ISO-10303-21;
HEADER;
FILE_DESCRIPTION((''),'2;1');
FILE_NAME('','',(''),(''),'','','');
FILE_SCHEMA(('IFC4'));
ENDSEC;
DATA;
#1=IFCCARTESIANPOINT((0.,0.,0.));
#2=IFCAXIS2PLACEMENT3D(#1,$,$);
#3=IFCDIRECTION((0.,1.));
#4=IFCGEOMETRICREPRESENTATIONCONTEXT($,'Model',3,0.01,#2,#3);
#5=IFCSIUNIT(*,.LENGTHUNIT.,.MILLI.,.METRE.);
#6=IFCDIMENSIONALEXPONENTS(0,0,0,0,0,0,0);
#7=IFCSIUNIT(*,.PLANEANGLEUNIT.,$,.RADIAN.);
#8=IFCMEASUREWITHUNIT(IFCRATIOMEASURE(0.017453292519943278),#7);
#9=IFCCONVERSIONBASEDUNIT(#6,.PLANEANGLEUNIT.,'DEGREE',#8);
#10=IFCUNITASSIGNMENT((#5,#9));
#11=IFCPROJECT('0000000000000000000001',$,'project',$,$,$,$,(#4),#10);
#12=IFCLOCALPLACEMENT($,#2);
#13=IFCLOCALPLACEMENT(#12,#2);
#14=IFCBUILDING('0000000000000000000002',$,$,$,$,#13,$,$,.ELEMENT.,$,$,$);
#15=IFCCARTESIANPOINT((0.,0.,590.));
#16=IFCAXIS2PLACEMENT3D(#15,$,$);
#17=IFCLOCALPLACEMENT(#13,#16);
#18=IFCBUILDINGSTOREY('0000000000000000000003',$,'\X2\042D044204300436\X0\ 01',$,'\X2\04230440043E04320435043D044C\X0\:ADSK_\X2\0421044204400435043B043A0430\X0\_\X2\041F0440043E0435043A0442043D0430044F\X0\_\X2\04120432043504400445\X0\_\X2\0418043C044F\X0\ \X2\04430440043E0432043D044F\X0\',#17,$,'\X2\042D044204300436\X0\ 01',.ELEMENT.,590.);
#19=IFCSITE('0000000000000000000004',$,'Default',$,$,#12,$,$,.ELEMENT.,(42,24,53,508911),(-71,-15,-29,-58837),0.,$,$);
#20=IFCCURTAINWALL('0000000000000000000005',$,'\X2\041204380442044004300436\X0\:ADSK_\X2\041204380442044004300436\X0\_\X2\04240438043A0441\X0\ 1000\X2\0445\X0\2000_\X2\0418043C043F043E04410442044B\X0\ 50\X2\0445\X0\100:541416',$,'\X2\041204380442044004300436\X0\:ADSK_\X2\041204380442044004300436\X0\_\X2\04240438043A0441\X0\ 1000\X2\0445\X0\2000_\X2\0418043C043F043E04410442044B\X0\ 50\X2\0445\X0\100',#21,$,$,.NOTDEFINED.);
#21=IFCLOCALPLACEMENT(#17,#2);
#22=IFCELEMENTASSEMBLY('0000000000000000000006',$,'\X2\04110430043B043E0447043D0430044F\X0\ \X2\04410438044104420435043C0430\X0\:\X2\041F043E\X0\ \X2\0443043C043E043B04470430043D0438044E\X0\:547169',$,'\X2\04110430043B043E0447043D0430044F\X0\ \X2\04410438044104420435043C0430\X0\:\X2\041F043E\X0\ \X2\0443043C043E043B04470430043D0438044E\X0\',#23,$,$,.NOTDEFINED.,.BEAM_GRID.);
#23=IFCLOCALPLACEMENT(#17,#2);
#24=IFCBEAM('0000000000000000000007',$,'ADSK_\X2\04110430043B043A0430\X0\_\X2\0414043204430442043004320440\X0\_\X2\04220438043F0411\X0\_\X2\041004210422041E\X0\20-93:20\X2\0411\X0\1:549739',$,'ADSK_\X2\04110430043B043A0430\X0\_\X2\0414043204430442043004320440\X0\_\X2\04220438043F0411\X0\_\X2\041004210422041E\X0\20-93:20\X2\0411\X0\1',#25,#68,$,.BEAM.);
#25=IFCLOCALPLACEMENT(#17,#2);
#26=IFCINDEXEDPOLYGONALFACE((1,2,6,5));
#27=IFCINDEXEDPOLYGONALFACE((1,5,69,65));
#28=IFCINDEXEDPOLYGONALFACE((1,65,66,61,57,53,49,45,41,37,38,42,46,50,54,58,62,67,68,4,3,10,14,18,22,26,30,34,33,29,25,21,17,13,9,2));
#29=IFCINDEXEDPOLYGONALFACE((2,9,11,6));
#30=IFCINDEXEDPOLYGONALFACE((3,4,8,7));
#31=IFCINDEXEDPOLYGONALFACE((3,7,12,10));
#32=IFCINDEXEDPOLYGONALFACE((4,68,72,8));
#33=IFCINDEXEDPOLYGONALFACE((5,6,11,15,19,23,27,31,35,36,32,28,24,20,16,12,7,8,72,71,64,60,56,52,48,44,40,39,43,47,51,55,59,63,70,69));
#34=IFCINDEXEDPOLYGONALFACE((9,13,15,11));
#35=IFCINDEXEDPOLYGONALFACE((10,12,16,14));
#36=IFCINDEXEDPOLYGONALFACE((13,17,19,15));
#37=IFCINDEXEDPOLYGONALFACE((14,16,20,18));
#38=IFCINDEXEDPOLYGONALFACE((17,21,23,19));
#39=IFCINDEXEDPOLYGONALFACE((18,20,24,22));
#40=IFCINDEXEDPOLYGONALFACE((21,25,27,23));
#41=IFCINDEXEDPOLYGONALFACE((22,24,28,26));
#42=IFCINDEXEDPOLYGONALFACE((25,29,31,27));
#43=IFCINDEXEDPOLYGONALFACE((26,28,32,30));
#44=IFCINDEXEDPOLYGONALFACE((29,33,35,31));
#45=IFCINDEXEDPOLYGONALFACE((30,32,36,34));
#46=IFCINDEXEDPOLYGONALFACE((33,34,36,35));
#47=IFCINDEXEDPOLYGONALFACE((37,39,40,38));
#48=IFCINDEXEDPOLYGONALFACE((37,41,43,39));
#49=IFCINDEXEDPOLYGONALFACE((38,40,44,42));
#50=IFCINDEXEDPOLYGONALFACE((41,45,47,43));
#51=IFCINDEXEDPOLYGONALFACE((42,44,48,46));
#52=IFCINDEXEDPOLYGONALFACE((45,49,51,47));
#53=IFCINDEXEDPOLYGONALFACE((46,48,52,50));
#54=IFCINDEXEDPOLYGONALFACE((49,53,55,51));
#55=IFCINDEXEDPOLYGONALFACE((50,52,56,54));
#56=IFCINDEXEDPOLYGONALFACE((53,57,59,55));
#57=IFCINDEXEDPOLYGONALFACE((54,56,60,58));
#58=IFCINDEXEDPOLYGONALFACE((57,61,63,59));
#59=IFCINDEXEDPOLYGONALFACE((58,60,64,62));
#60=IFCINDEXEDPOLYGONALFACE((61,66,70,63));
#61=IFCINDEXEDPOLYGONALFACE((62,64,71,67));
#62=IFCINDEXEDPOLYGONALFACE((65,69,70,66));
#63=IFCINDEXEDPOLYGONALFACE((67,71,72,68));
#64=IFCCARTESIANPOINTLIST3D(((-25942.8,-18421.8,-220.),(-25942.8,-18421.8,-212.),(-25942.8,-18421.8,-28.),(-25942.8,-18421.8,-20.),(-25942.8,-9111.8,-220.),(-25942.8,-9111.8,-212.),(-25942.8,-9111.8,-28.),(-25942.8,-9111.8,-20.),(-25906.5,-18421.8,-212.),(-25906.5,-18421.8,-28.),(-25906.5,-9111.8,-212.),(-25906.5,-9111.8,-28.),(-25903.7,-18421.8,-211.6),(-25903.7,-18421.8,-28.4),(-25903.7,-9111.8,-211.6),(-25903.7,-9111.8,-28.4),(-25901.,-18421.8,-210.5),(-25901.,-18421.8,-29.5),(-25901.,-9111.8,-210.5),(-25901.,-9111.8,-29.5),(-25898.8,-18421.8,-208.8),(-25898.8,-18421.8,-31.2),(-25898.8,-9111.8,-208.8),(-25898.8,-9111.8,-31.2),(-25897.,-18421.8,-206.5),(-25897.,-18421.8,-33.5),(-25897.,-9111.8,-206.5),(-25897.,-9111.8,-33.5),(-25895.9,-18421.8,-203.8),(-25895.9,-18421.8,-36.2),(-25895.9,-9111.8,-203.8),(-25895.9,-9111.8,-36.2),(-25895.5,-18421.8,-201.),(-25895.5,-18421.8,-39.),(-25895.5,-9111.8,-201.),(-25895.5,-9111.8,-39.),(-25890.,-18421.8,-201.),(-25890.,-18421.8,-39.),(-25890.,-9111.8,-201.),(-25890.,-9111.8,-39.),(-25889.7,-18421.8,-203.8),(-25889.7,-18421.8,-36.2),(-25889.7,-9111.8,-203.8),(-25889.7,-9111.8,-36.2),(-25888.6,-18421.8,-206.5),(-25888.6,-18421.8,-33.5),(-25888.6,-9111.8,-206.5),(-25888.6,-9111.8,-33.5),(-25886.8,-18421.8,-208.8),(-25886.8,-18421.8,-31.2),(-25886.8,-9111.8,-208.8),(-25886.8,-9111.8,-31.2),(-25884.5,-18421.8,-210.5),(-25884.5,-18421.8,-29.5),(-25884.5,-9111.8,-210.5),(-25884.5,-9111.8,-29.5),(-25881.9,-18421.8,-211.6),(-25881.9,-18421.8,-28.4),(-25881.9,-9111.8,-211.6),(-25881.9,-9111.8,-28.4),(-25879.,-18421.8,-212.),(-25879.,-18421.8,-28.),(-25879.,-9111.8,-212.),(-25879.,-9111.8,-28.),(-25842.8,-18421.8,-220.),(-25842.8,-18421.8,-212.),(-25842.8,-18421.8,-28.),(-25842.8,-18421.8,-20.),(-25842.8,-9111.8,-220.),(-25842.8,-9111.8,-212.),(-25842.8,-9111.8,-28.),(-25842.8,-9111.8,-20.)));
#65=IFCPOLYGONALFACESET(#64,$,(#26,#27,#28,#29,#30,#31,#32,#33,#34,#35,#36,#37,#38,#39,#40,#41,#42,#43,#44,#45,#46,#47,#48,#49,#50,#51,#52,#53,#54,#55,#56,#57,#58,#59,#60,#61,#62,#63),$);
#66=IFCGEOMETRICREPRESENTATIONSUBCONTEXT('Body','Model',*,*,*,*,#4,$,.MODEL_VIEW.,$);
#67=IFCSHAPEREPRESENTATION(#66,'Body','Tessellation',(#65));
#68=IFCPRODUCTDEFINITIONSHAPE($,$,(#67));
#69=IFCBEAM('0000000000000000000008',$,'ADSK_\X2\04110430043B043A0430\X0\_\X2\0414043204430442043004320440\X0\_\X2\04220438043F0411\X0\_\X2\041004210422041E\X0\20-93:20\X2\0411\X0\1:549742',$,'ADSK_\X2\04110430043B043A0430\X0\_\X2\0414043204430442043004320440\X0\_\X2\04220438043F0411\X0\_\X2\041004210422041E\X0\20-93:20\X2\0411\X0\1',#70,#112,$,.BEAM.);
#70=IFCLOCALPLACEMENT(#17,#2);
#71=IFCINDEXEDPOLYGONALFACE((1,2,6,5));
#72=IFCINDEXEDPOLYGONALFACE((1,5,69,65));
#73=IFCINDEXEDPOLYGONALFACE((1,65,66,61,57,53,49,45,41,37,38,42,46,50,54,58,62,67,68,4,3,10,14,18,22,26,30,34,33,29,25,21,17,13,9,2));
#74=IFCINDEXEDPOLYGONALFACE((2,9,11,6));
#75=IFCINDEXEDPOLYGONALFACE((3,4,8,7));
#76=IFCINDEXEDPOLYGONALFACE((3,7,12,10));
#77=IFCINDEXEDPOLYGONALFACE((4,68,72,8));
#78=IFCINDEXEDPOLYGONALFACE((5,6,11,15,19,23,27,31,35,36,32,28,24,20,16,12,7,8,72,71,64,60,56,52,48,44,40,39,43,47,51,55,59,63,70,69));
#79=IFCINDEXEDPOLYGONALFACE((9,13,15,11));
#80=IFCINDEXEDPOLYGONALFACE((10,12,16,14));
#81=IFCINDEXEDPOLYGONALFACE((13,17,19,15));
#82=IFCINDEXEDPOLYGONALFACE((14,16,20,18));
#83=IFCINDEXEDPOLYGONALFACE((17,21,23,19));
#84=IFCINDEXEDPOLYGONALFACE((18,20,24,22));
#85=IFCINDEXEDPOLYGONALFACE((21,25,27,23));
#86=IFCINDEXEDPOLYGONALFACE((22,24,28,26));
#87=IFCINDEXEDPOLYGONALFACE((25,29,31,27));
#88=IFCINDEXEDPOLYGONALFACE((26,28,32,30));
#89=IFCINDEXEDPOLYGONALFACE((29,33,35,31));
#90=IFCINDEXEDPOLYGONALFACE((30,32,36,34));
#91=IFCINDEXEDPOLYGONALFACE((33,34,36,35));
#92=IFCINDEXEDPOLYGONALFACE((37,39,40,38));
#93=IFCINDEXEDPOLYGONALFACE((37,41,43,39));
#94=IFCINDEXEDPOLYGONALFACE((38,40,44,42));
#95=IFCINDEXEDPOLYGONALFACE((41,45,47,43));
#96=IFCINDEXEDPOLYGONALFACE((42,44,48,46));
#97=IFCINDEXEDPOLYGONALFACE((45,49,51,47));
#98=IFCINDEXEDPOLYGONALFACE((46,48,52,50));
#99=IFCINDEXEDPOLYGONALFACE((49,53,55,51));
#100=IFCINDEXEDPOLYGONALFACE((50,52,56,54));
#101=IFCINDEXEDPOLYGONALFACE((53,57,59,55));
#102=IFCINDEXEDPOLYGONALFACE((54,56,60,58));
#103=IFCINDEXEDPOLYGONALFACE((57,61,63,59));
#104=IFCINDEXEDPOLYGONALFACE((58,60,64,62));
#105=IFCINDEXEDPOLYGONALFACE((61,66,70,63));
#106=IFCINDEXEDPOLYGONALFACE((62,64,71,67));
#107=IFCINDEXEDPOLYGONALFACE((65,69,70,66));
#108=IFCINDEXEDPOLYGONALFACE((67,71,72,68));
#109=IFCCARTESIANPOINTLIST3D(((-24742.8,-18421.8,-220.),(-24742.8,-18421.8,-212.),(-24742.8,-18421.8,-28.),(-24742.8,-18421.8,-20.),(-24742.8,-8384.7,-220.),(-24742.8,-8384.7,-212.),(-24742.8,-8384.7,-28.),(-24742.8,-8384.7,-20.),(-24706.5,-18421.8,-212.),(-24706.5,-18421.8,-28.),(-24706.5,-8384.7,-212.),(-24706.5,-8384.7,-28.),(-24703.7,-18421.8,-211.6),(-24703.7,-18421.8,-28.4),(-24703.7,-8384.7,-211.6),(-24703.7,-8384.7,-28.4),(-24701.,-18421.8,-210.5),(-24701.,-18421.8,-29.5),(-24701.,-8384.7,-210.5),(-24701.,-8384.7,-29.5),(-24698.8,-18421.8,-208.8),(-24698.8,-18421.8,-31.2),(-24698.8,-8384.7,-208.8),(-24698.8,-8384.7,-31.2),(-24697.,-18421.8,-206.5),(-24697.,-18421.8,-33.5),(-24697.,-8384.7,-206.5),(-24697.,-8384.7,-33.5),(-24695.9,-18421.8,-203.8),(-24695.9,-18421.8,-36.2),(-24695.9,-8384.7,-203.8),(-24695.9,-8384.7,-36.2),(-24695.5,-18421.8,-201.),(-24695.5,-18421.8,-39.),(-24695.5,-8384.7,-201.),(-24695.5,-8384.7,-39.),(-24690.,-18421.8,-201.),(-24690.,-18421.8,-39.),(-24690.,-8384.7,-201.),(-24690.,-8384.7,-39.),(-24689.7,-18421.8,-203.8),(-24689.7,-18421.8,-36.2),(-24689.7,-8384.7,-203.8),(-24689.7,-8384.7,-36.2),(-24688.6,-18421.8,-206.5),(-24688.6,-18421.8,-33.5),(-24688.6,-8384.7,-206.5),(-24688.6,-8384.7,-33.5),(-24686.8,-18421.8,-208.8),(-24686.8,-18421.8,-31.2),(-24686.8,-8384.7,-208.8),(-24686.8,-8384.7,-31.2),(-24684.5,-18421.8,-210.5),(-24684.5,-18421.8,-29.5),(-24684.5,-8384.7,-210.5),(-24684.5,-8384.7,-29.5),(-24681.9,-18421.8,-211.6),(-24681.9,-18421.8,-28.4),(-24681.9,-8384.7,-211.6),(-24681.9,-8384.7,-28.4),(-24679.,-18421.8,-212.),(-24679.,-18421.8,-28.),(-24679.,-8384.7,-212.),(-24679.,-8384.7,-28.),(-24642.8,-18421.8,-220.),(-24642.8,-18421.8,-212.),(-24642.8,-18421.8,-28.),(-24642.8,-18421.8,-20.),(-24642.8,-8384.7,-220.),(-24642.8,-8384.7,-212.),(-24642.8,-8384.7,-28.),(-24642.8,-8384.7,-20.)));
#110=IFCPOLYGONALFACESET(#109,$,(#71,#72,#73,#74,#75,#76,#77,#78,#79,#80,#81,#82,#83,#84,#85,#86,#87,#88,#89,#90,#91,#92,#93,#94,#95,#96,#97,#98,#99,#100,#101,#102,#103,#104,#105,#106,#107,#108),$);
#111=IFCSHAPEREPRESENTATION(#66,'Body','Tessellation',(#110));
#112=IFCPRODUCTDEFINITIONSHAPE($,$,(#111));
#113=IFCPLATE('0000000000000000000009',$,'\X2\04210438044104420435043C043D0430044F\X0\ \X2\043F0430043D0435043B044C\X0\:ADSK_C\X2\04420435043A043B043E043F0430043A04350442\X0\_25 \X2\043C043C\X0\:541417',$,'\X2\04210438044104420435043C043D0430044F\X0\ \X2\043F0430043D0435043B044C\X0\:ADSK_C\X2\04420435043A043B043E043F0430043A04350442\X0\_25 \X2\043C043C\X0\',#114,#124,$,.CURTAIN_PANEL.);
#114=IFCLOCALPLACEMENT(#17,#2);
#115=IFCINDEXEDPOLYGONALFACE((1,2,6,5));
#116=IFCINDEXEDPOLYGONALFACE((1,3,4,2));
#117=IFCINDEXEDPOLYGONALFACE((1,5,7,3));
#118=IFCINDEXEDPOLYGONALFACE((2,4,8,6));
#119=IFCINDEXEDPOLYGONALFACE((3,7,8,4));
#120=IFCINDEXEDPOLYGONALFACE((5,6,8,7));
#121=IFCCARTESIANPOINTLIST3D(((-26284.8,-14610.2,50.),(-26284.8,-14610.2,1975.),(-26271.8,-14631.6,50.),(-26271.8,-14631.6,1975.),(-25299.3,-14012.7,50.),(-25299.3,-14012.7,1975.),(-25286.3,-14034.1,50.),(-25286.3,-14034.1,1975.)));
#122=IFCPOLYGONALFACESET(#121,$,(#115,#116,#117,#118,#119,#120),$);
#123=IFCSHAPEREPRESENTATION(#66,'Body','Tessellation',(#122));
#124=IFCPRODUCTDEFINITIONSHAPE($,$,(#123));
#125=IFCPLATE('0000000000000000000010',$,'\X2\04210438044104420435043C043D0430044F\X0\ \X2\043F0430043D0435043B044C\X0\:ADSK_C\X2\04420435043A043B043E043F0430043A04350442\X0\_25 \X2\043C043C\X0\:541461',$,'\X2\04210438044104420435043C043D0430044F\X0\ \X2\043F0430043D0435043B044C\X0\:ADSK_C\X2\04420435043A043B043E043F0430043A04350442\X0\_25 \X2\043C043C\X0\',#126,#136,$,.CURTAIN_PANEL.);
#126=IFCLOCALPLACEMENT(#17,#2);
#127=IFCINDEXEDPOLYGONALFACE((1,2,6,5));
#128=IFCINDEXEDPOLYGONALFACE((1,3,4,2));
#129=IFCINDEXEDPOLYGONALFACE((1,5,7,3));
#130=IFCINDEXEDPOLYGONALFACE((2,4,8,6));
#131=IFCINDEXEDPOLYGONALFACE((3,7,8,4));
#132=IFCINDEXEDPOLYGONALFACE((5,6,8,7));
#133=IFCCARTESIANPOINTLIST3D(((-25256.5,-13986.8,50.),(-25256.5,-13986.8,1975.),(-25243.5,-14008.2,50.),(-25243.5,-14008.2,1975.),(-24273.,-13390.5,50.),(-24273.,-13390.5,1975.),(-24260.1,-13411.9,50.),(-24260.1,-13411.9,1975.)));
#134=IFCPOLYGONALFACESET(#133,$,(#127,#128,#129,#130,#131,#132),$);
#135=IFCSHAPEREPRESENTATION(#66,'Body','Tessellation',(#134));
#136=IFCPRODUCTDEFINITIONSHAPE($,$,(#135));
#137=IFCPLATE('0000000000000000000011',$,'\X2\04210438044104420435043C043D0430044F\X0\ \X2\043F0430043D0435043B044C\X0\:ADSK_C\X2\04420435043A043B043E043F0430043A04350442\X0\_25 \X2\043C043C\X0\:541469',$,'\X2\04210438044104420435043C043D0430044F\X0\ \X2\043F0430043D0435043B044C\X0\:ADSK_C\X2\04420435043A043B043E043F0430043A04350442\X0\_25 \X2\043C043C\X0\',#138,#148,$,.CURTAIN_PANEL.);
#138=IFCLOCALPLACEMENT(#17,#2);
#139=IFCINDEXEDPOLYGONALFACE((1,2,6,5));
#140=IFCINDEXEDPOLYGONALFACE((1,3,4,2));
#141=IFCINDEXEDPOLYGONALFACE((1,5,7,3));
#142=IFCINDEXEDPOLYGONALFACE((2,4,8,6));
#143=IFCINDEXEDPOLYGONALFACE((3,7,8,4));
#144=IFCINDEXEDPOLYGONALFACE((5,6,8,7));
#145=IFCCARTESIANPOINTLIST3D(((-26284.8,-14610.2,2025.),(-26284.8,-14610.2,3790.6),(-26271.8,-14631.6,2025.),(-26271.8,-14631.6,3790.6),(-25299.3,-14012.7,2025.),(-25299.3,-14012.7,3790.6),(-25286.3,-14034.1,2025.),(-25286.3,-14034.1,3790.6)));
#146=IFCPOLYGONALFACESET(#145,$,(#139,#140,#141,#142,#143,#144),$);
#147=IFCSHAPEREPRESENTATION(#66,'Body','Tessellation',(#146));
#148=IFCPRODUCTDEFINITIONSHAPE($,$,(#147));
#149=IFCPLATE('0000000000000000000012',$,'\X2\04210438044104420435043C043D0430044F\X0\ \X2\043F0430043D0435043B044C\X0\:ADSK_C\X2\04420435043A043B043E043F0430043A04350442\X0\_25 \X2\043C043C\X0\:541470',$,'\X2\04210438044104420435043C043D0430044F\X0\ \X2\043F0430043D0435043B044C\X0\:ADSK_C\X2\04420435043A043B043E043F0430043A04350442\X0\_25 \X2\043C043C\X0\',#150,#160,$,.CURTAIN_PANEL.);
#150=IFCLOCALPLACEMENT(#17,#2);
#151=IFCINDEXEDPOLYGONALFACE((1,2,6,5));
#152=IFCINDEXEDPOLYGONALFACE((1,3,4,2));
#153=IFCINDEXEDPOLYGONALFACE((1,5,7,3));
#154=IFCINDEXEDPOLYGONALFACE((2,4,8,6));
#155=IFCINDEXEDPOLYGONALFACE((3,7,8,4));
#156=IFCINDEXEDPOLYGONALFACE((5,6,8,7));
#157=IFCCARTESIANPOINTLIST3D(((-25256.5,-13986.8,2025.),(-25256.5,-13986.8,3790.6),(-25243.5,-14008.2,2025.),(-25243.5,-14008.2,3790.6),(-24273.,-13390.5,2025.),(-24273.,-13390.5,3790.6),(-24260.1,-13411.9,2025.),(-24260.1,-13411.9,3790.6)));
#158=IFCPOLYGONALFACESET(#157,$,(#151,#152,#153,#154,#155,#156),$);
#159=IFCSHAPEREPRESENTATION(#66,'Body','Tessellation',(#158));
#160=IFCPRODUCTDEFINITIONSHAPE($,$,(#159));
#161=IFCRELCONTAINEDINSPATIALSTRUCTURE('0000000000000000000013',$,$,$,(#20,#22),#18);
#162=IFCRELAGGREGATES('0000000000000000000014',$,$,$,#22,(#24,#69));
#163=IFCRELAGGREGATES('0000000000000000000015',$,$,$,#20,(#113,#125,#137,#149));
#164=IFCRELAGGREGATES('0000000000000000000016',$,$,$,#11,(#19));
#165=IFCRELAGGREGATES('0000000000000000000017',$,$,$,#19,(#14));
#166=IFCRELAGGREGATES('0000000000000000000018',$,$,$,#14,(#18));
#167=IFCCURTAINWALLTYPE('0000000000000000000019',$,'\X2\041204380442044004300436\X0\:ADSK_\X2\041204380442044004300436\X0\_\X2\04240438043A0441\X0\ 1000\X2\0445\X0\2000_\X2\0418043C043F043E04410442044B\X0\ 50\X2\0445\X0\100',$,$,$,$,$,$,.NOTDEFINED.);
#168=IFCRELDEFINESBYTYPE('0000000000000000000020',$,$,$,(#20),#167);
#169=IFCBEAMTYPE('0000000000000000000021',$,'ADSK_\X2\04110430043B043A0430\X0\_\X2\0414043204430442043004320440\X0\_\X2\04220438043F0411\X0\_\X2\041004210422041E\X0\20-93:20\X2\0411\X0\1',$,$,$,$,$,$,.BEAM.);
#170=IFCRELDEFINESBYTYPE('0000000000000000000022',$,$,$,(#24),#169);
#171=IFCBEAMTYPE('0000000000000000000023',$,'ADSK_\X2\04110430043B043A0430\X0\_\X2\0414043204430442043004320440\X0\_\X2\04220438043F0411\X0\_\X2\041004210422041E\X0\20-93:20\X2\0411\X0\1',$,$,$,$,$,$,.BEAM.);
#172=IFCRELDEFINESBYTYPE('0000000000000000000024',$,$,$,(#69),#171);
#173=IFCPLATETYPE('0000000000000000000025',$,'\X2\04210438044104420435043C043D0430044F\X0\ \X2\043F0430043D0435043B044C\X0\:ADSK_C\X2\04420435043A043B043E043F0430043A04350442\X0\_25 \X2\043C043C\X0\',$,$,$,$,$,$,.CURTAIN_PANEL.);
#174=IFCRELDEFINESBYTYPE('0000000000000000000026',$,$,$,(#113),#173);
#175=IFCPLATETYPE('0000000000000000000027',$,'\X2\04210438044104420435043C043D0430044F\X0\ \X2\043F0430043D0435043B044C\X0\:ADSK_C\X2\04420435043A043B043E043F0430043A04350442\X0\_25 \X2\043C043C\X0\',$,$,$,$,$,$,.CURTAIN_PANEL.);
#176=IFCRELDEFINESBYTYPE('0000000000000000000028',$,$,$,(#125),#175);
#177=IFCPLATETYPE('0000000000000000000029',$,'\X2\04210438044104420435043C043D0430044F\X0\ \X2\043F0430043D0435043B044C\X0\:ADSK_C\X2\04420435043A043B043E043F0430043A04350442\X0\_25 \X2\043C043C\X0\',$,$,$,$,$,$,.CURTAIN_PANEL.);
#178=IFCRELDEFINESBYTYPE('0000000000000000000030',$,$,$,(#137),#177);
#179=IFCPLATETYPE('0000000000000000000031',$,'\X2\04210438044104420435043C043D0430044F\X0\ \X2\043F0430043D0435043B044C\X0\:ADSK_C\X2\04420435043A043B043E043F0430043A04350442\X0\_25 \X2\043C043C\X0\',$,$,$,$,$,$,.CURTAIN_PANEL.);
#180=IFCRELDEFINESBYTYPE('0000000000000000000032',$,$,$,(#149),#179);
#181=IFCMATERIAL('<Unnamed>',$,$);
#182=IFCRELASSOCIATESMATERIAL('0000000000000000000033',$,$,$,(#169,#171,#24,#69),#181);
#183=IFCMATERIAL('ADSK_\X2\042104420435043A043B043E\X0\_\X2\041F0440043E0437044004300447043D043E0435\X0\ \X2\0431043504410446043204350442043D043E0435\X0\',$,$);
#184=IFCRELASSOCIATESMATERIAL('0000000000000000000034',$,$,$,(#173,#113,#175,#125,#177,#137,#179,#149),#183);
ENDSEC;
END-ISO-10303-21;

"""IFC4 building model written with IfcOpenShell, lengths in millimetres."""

from ifc_helpers import new_model, entity, si_unit, converted_unit, direction, frame, frame_2d, origin, place, context, subcontext, project, spatial, polyline, circle_curve, parameter, trimmed, segment, composite_curve, rectangle, i_section, outline, extrude, source, transform, mapped, material, material_profile, profile_set, profile_usage, type_object, type_shapes, element, aggregate, save


model = new_model("IFC4")

# Units and contexts
model_context = context("Model", 3, precision=0.01, world=origin(), true_north=direction((0.0, 1.0)))
body_context = subcontext(model_context, "Body", "Model", "MODEL_VIEW")
ifc_project = project(units=[si_unit("LENGTHUNIT", "METRE", prefix="MILLI"), converted_unit("PLANEANGLEUNIT", "DEGREE", entity("IfcRatioMeasure", 0.017453292519943278), si_unit("PLANEANGLEUNIT", "RADIAN"), dimensions=[0, 0, 0, 0, 0, 0, 0])], contexts=[model_context])

# Site, building, storey
site_placement = place(None, origin())
site = spatial("IfcSite", under=ifc_project, at=site_placement, Name="Default", CompositionType="ELEMENT", RefLatitude=(42, 24, 53, 508911), RefLongitude=(-71, -15, -29, -58837), RefElevation=0.0)
building_placement = place(site_placement, origin())
building = spatial("IfcBuilding", under=site, at=building_placement, CompositionType="ELEMENT")
storey_placement = place(building_placement, frame((0.0, 0.0, 590.0)))
storey = spatial("IfcBuildingStorey", under=building, at=storey_placement, Name="Этаж 01", ObjectType="Уровень:ADSK_Стрелка_Проектная_Вверх_Имя уровня", LongName="Этаж 01", CompositionType="ELEMENT", Elevation=590.0)

# Curtain wall
curtain_wall_type = type_object("IfcCurtainWallType", Name="Витраж:ADSK_Витраж_Фикс 1000х2000_Импосты 50х100", PredefinedType="NOTDEFINED")
curtain_wall_placement = place(storey_placement, frame((0.0, 0.0, -590.0)))
curtain_wall = element("IfcCurtainWall", 1, at=curtain_wall_placement, inside=storey, type_object=curtain_wall_type, Name="Витраж:ADSK_Витраж_Фикс 1000х2000_Импосты 50х100:541416", ObjectType="Витраж:ADSK_Витраж_Фикс 1000х2000_Импосты 50х100", PredefinedType="NOTDEFINED")
ifc_material_1 = material(Name="<Unnamed>")

# Element assembly, beams
assembly_placement = place(storey_placement, origin())
assembly = element("IfcElementAssembly", 2, at=assembly_placement, inside=storey, Name="Балочная система:По умолчанию:547169", ObjectType="Балочная система:По умолчанию", AssemblyPlace="NOTDEFINED", PredefinedType="BEAM_GRID")
ifc_material_profile_1 = material_profile(ifc_material_1, outline(composite_curve([segment(polyline([(13.7, -192.0, 0.0), (50.0, -192.0, 0.0)]), True, "CONTINUOUS"), segment(polyline([(50.0, -192.0, 0.0), (50.0, -200.0, 0.0)]), True, "CONTINUOUS"), segment(polyline([(50.0, -200.0, 0.0), (-50.0, -200.0, 0.0)]), True, "CONTINUOUS"), segment(polyline([(-50.0, -200.0, 0.0), (-50.0, -192.0, 0.0)]), True, "CONTINUOUS"), segment(polyline([(-50.0, -192.0, 0.0), (-13.8, -192.0, 0.0)]), True, "CONTINUOUS"), segment(trimmed(circle_curve(frame((-13.8, -181.0, 0.0), z_axis=(0.0, 0.0, 1.0), x_axis=(-1.0, 0.0, 0.0)), 11.0), [parameter(90.0)], [parameter(180.0)], True, "PARAMETER"), True, "CONTINUOUS"), segment(polyline([(-2.8, -181.0, 0.0), (-2.8, -19.0, 0.0)]), True, "CONTINUOUS"), segment(trimmed(circle_curve(frame((-13.8, -19.0, 0.0), z_axis=(0.0, 0.0, 1.0), x_axis=(-1.0, 0.0, 0.0)), 11.0), [parameter(180.0)], [parameter(270.0)], True, "PARAMETER"), True, "CONTINUOUS"), segment(polyline([(-13.8, -8.0, 0.0), (-50.0, -8.0, 0.0)]), True, "CONTINUOUS"), segment(polyline([(-50.0, -8.0, 0.0), (-50.0, 0.0, 0.0)]), True, "CONTINUOUS"), segment(polyline([(-50.0, 0.0, 0.0), (50.0, 0.0, 0.0)]), True, "CONTINUOUS"), segment(polyline([(50.0, 0.0, 0.0), (50.0, -8.0, 0.0)]), True, "CONTINUOUS"), segment(polyline([(50.0, -8.0, 0.0), (13.7, -8.0, 0.0)]), True, "CONTINUOUS"), segment(trimmed(circle_curve(frame((13.7, -19.0, 0.0), z_axis=(0.0, 0.0, 1.0), x_axis=(-1.0, 0.0, 0.0)), 11.0), [parameter(270.0)], [parameter(0.0)], True, "PARAMETER"), True, "CONTINUOUS"), segment(polyline([(2.7, -19.0, 0.0), (2.7, -181.0, 0.0)]), True, "CONTINUOUS"), segment(trimmed(circle_curve(frame((13.7, -181.0, 0.0), z_axis=(0.0, 0.0, 1.0), x_axis=(-1.0, 0.0, 0.0)), 11.0), [parameter(0.0)], [parameter(90.0)], True, "PARAMETER"), True, "CONTINUOUS")], self_intersect=False), kind="CURVE"), Name="20Б1")
ifc_profile_set_1 = profile_set([ifc_material_profile_1], Name="20Б1")
ifc_profile_usage_1 = profile_usage(ifc_profile_set_1, cardinal=8)
beam_type_1 = type_object("IfcBeamType", Name="ADSK_Балка_Двутавр_ТипБ_АСТО20-93:20Б1", PredefinedType="BEAM", material=ifc_profile_set_1)
shared_shape_1 = source(origin(), body_context, "Body", "SweptSolid", [
    extrude(i_section(OverallWidth=100.0, OverallDepth=200.0, WebThickness=5.5, FlangeThickness=8.0, FilletRadius=11.0, at=frame_2d((0.0, 0.0), x_axis=(0.0, 1.0))), frame((-4655.0, 0.0, -100.0), z_axis=(1.0, 0.0, 0.0), x_axis=(0.0, 0.0, -1.0)), (0.0, 0.0, 1.0), 9310.0),
])
type_shapes(beam_type_1, [shared_shape_1])
beam_1_placement = place(assembly_placement, frame((-25892.8, -13766.8, -20.0), z_axis=(0.0, 0.0, 1.0), x_axis=(0.0, 1.0, 0.0)))
beam_1 = element("IfcBeam", 3, at=beam_1_placement, type_object=beam_type_1, material=ifc_profile_usage_1, Name="ADSK_Балка_Двутавр_ТипБ_АСТО20-93:20Б1:549739", ObjectType="ADSK_Балка_Двутавр_ТипБ_АСТО20-93:20Б1", PredefinedType="BEAM", context=body_context, shape_type="MappedRepresentation", body=[
    mapped(shared_shape_1, transform((0.0, 0.0, 0.0), scale=1.0)),
])
ifc_profile_usage_2 = profile_usage(ifc_profile_set_1, cardinal=8)
beam_type_2 = type_object("IfcBeamType", Name="ADSK_Балка_Двутавр_ТипБ_АСТО20-93:20Б1", PredefinedType="BEAM", material=ifc_profile_set_1)
shared_shape_2 = source(origin(), body_context, "Body", "SweptSolid", [
    extrude(i_section(OverallWidth=100.0, OverallDepth=200.0, WebThickness=5.5, FlangeThickness=8.0, FilletRadius=11.0, at=frame_2d((0.0, 0.0), x_axis=(0.0, 1.0))), frame((-5018.6, 0.0, -100.0), z_axis=(1.0, 0.0, 0.0), x_axis=(0.0, 0.0, -1.0)), (0.0, 0.0, 1.0), 10037.1),
])
type_shapes(beam_type_2, [shared_shape_2])
beam_2_placement = place(assembly_placement, frame((-24692.8, -13403.2, -20.0), z_axis=(0.0, 0.0, 1.0), x_axis=(0.0, 1.0, 0.0)))
beam_2 = element("IfcBeam", 4, at=beam_2_placement, type_object=beam_type_2, material=ifc_profile_usage_2, Name="ADSK_Балка_Двутавр_ТипБ_АСТО20-93:20Б1:549742", ObjectType="ADSK_Балка_Двутавр_ТипБ_АСТО20-93:20Б1", PredefinedType="BEAM", context=body_context, shape_type="MappedRepresentation", body=[
    mapped(shared_shape_2, transform((0.0, 0.0, 0.0), scale=1.0)),
])
aggregate(assembly, [beam_1, beam_2])

# Plates
ifc_material_2 = material(Name="ADSK_Стекло_Прозрачное бесцветное")
plate_type_1 = type_object("IfcPlateType", Name="Системная панель:ADSK_Cтеклопакет_25 мм", PredefinedType="CURTAIN_PANEL", material=ifc_material_2)
shared_shape_3 = source(origin(), body_context, "Body", "SweptSolid", [
    extrude(rectangle(XDim=25.0, YDim=1152.5, at=frame_2d((0.0, 0.0), x_axis=(1.0, 0.0))), frame((0.0, 0.0, 0.0), z_axis=(0.0, 0.0, 1.0), x_axis=(0.0, 1.0, 0.0)), (0.0, 0.0, 1.0), 1925.0),
])
type_shapes(plate_type_1, [shared_shape_3])
plate_1_placement = place(curtain_wall_placement, frame((-25785.5, -14322.2, 640.0), z_axis=(0.0, 0.0, 1.0), x_axis=(0.855102, 0.51846, 0.0)))
plate_1 = element("IfcPlate", 5, at=plate_1_placement, type_object=plate_type_1, material=ifc_material_2, Name="Системная панель:ADSK_Cтеклопакет_25 мм:541417", ObjectType="Системная панель:ADSK_Cтеклопакет_25 мм", PredefinedType="CURTAIN_PANEL", context=body_context, shape_type="MappedRepresentation", body=[
    mapped(shared_shape_3, transform((0.0, 0.0, 0.0), scale=1.0)),
])
plate_type_2 = type_object("IfcPlateType", Name="Системная панель:ADSK_Cтеклопакет_25 мм", PredefinedType="CURTAIN_PANEL", material=ifc_material_2)
shared_shape_4 = source(origin(), body_context, "Body", "SweptSolid", [
    extrude(rectangle(XDim=25.0, YDim=1150.1, at=frame_2d((0.0, 0.0), x_axis=(1.0, 0.0))), frame((0.0, 0.0, 0.0), z_axis=(0.0, 0.0, 1.0), x_axis=(0.0, 1.0, 0.0)), (0.0, 0.0, 1.0), 1925.0),
])
type_shapes(plate_type_2, [shared_shape_4])
plate_2_placement = place(curtain_wall_placement, frame((-24758.3, -13699.3, 640.0), z_axis=(0.0, 0.0, 1.0), x_axis=(0.855102, 0.51846, 0.0)))
plate_2 = element("IfcPlate", 6, at=plate_2_placement, type_object=plate_type_2, material=ifc_material_2, Name="Системная панель:ADSK_Cтеклопакет_25 мм:541461", ObjectType="Системная панель:ADSK_Cтеклопакет_25 мм", PredefinedType="CURTAIN_PANEL", context=body_context, shape_type="MappedRepresentation", body=[
    mapped(shared_shape_4, transform((0.0, 0.0, 0.0), scale=1.0)),
])
plate_type_3 = type_object("IfcPlateType", Name="Системная панель:ADSK_Cтеклопакет_25 мм", PredefinedType="CURTAIN_PANEL", material=ifc_material_2)
shared_shape_5 = source(origin(), body_context, "Body", "SweptSolid", [
    extrude(rectangle(XDim=25.0, YDim=1152.5, at=frame_2d((0.0, 0.0), x_axis=(1.0, 0.0))), frame((0.0, 0.0, 0.0), z_axis=(0.0, 0.0, 1.0), x_axis=(0.0, 1.0, 0.0)), (0.0, 0.0, 1.0), 1765.6),
])
type_shapes(plate_type_3, [shared_shape_5])
plate_3_placement = place(curtain_wall_placement, frame((-25785.5, -14322.2, 2615.0), z_axis=(0.0, 0.0, 1.0), x_axis=(0.855102, 0.51846, 0.0)))
plate_3 = element("IfcPlate", 7, at=plate_3_placement, type_object=plate_type_3, material=ifc_material_2, Name="Системная панель:ADSK_Cтеклопакет_25 мм:541469", ObjectType="Системная панель:ADSK_Cтеклопакет_25 мм", PredefinedType="CURTAIN_PANEL", context=body_context, shape_type="MappedRepresentation", body=[
    mapped(shared_shape_5, transform((0.0, 0.0, 0.0), scale=1.0)),
])
plate_type_4 = type_object("IfcPlateType", Name="Системная панель:ADSK_Cтеклопакет_25 мм", PredefinedType="CURTAIN_PANEL", material=ifc_material_2)
shared_shape_6 = source(origin(), body_context, "Body", "SweptSolid", [
    extrude(rectangle(XDim=25.0, YDim=1150.1, at=frame_2d((0.0, 0.0), x_axis=(1.0, 0.0))), frame((0.0, 0.0, 0.0), z_axis=(0.0, 0.0, 1.0), x_axis=(0.0, 1.0, 0.0)), (0.0, 0.0, 1.0), 1765.6),
])
type_shapes(plate_type_4, [shared_shape_6])
plate_4_placement = place(curtain_wall_placement, frame((-24758.3, -13699.3, 2615.0), z_axis=(0.0, 0.0, 1.0), x_axis=(0.855102, 0.51846, 0.0)))
plate_4 = element("IfcPlate", 8, at=plate_4_placement, type_object=plate_type_4, material=ifc_material_2, Name="Системная панель:ADSK_Cтеклопакет_25 мм:541470", ObjectType="Системная панель:ADSK_Cтеклопакет_25 мм", PredefinedType="CURTAIN_PANEL", context=body_context, shape_type="MappedRepresentation", body=[
    mapped(shared_shape_6, transform((0.0, 0.0, 0.0), scale=1.0)),
])
aggregate(curtain_wall, [plate_1, plate_2, plate_3, plate_4])

save(model, "model.ifc")
